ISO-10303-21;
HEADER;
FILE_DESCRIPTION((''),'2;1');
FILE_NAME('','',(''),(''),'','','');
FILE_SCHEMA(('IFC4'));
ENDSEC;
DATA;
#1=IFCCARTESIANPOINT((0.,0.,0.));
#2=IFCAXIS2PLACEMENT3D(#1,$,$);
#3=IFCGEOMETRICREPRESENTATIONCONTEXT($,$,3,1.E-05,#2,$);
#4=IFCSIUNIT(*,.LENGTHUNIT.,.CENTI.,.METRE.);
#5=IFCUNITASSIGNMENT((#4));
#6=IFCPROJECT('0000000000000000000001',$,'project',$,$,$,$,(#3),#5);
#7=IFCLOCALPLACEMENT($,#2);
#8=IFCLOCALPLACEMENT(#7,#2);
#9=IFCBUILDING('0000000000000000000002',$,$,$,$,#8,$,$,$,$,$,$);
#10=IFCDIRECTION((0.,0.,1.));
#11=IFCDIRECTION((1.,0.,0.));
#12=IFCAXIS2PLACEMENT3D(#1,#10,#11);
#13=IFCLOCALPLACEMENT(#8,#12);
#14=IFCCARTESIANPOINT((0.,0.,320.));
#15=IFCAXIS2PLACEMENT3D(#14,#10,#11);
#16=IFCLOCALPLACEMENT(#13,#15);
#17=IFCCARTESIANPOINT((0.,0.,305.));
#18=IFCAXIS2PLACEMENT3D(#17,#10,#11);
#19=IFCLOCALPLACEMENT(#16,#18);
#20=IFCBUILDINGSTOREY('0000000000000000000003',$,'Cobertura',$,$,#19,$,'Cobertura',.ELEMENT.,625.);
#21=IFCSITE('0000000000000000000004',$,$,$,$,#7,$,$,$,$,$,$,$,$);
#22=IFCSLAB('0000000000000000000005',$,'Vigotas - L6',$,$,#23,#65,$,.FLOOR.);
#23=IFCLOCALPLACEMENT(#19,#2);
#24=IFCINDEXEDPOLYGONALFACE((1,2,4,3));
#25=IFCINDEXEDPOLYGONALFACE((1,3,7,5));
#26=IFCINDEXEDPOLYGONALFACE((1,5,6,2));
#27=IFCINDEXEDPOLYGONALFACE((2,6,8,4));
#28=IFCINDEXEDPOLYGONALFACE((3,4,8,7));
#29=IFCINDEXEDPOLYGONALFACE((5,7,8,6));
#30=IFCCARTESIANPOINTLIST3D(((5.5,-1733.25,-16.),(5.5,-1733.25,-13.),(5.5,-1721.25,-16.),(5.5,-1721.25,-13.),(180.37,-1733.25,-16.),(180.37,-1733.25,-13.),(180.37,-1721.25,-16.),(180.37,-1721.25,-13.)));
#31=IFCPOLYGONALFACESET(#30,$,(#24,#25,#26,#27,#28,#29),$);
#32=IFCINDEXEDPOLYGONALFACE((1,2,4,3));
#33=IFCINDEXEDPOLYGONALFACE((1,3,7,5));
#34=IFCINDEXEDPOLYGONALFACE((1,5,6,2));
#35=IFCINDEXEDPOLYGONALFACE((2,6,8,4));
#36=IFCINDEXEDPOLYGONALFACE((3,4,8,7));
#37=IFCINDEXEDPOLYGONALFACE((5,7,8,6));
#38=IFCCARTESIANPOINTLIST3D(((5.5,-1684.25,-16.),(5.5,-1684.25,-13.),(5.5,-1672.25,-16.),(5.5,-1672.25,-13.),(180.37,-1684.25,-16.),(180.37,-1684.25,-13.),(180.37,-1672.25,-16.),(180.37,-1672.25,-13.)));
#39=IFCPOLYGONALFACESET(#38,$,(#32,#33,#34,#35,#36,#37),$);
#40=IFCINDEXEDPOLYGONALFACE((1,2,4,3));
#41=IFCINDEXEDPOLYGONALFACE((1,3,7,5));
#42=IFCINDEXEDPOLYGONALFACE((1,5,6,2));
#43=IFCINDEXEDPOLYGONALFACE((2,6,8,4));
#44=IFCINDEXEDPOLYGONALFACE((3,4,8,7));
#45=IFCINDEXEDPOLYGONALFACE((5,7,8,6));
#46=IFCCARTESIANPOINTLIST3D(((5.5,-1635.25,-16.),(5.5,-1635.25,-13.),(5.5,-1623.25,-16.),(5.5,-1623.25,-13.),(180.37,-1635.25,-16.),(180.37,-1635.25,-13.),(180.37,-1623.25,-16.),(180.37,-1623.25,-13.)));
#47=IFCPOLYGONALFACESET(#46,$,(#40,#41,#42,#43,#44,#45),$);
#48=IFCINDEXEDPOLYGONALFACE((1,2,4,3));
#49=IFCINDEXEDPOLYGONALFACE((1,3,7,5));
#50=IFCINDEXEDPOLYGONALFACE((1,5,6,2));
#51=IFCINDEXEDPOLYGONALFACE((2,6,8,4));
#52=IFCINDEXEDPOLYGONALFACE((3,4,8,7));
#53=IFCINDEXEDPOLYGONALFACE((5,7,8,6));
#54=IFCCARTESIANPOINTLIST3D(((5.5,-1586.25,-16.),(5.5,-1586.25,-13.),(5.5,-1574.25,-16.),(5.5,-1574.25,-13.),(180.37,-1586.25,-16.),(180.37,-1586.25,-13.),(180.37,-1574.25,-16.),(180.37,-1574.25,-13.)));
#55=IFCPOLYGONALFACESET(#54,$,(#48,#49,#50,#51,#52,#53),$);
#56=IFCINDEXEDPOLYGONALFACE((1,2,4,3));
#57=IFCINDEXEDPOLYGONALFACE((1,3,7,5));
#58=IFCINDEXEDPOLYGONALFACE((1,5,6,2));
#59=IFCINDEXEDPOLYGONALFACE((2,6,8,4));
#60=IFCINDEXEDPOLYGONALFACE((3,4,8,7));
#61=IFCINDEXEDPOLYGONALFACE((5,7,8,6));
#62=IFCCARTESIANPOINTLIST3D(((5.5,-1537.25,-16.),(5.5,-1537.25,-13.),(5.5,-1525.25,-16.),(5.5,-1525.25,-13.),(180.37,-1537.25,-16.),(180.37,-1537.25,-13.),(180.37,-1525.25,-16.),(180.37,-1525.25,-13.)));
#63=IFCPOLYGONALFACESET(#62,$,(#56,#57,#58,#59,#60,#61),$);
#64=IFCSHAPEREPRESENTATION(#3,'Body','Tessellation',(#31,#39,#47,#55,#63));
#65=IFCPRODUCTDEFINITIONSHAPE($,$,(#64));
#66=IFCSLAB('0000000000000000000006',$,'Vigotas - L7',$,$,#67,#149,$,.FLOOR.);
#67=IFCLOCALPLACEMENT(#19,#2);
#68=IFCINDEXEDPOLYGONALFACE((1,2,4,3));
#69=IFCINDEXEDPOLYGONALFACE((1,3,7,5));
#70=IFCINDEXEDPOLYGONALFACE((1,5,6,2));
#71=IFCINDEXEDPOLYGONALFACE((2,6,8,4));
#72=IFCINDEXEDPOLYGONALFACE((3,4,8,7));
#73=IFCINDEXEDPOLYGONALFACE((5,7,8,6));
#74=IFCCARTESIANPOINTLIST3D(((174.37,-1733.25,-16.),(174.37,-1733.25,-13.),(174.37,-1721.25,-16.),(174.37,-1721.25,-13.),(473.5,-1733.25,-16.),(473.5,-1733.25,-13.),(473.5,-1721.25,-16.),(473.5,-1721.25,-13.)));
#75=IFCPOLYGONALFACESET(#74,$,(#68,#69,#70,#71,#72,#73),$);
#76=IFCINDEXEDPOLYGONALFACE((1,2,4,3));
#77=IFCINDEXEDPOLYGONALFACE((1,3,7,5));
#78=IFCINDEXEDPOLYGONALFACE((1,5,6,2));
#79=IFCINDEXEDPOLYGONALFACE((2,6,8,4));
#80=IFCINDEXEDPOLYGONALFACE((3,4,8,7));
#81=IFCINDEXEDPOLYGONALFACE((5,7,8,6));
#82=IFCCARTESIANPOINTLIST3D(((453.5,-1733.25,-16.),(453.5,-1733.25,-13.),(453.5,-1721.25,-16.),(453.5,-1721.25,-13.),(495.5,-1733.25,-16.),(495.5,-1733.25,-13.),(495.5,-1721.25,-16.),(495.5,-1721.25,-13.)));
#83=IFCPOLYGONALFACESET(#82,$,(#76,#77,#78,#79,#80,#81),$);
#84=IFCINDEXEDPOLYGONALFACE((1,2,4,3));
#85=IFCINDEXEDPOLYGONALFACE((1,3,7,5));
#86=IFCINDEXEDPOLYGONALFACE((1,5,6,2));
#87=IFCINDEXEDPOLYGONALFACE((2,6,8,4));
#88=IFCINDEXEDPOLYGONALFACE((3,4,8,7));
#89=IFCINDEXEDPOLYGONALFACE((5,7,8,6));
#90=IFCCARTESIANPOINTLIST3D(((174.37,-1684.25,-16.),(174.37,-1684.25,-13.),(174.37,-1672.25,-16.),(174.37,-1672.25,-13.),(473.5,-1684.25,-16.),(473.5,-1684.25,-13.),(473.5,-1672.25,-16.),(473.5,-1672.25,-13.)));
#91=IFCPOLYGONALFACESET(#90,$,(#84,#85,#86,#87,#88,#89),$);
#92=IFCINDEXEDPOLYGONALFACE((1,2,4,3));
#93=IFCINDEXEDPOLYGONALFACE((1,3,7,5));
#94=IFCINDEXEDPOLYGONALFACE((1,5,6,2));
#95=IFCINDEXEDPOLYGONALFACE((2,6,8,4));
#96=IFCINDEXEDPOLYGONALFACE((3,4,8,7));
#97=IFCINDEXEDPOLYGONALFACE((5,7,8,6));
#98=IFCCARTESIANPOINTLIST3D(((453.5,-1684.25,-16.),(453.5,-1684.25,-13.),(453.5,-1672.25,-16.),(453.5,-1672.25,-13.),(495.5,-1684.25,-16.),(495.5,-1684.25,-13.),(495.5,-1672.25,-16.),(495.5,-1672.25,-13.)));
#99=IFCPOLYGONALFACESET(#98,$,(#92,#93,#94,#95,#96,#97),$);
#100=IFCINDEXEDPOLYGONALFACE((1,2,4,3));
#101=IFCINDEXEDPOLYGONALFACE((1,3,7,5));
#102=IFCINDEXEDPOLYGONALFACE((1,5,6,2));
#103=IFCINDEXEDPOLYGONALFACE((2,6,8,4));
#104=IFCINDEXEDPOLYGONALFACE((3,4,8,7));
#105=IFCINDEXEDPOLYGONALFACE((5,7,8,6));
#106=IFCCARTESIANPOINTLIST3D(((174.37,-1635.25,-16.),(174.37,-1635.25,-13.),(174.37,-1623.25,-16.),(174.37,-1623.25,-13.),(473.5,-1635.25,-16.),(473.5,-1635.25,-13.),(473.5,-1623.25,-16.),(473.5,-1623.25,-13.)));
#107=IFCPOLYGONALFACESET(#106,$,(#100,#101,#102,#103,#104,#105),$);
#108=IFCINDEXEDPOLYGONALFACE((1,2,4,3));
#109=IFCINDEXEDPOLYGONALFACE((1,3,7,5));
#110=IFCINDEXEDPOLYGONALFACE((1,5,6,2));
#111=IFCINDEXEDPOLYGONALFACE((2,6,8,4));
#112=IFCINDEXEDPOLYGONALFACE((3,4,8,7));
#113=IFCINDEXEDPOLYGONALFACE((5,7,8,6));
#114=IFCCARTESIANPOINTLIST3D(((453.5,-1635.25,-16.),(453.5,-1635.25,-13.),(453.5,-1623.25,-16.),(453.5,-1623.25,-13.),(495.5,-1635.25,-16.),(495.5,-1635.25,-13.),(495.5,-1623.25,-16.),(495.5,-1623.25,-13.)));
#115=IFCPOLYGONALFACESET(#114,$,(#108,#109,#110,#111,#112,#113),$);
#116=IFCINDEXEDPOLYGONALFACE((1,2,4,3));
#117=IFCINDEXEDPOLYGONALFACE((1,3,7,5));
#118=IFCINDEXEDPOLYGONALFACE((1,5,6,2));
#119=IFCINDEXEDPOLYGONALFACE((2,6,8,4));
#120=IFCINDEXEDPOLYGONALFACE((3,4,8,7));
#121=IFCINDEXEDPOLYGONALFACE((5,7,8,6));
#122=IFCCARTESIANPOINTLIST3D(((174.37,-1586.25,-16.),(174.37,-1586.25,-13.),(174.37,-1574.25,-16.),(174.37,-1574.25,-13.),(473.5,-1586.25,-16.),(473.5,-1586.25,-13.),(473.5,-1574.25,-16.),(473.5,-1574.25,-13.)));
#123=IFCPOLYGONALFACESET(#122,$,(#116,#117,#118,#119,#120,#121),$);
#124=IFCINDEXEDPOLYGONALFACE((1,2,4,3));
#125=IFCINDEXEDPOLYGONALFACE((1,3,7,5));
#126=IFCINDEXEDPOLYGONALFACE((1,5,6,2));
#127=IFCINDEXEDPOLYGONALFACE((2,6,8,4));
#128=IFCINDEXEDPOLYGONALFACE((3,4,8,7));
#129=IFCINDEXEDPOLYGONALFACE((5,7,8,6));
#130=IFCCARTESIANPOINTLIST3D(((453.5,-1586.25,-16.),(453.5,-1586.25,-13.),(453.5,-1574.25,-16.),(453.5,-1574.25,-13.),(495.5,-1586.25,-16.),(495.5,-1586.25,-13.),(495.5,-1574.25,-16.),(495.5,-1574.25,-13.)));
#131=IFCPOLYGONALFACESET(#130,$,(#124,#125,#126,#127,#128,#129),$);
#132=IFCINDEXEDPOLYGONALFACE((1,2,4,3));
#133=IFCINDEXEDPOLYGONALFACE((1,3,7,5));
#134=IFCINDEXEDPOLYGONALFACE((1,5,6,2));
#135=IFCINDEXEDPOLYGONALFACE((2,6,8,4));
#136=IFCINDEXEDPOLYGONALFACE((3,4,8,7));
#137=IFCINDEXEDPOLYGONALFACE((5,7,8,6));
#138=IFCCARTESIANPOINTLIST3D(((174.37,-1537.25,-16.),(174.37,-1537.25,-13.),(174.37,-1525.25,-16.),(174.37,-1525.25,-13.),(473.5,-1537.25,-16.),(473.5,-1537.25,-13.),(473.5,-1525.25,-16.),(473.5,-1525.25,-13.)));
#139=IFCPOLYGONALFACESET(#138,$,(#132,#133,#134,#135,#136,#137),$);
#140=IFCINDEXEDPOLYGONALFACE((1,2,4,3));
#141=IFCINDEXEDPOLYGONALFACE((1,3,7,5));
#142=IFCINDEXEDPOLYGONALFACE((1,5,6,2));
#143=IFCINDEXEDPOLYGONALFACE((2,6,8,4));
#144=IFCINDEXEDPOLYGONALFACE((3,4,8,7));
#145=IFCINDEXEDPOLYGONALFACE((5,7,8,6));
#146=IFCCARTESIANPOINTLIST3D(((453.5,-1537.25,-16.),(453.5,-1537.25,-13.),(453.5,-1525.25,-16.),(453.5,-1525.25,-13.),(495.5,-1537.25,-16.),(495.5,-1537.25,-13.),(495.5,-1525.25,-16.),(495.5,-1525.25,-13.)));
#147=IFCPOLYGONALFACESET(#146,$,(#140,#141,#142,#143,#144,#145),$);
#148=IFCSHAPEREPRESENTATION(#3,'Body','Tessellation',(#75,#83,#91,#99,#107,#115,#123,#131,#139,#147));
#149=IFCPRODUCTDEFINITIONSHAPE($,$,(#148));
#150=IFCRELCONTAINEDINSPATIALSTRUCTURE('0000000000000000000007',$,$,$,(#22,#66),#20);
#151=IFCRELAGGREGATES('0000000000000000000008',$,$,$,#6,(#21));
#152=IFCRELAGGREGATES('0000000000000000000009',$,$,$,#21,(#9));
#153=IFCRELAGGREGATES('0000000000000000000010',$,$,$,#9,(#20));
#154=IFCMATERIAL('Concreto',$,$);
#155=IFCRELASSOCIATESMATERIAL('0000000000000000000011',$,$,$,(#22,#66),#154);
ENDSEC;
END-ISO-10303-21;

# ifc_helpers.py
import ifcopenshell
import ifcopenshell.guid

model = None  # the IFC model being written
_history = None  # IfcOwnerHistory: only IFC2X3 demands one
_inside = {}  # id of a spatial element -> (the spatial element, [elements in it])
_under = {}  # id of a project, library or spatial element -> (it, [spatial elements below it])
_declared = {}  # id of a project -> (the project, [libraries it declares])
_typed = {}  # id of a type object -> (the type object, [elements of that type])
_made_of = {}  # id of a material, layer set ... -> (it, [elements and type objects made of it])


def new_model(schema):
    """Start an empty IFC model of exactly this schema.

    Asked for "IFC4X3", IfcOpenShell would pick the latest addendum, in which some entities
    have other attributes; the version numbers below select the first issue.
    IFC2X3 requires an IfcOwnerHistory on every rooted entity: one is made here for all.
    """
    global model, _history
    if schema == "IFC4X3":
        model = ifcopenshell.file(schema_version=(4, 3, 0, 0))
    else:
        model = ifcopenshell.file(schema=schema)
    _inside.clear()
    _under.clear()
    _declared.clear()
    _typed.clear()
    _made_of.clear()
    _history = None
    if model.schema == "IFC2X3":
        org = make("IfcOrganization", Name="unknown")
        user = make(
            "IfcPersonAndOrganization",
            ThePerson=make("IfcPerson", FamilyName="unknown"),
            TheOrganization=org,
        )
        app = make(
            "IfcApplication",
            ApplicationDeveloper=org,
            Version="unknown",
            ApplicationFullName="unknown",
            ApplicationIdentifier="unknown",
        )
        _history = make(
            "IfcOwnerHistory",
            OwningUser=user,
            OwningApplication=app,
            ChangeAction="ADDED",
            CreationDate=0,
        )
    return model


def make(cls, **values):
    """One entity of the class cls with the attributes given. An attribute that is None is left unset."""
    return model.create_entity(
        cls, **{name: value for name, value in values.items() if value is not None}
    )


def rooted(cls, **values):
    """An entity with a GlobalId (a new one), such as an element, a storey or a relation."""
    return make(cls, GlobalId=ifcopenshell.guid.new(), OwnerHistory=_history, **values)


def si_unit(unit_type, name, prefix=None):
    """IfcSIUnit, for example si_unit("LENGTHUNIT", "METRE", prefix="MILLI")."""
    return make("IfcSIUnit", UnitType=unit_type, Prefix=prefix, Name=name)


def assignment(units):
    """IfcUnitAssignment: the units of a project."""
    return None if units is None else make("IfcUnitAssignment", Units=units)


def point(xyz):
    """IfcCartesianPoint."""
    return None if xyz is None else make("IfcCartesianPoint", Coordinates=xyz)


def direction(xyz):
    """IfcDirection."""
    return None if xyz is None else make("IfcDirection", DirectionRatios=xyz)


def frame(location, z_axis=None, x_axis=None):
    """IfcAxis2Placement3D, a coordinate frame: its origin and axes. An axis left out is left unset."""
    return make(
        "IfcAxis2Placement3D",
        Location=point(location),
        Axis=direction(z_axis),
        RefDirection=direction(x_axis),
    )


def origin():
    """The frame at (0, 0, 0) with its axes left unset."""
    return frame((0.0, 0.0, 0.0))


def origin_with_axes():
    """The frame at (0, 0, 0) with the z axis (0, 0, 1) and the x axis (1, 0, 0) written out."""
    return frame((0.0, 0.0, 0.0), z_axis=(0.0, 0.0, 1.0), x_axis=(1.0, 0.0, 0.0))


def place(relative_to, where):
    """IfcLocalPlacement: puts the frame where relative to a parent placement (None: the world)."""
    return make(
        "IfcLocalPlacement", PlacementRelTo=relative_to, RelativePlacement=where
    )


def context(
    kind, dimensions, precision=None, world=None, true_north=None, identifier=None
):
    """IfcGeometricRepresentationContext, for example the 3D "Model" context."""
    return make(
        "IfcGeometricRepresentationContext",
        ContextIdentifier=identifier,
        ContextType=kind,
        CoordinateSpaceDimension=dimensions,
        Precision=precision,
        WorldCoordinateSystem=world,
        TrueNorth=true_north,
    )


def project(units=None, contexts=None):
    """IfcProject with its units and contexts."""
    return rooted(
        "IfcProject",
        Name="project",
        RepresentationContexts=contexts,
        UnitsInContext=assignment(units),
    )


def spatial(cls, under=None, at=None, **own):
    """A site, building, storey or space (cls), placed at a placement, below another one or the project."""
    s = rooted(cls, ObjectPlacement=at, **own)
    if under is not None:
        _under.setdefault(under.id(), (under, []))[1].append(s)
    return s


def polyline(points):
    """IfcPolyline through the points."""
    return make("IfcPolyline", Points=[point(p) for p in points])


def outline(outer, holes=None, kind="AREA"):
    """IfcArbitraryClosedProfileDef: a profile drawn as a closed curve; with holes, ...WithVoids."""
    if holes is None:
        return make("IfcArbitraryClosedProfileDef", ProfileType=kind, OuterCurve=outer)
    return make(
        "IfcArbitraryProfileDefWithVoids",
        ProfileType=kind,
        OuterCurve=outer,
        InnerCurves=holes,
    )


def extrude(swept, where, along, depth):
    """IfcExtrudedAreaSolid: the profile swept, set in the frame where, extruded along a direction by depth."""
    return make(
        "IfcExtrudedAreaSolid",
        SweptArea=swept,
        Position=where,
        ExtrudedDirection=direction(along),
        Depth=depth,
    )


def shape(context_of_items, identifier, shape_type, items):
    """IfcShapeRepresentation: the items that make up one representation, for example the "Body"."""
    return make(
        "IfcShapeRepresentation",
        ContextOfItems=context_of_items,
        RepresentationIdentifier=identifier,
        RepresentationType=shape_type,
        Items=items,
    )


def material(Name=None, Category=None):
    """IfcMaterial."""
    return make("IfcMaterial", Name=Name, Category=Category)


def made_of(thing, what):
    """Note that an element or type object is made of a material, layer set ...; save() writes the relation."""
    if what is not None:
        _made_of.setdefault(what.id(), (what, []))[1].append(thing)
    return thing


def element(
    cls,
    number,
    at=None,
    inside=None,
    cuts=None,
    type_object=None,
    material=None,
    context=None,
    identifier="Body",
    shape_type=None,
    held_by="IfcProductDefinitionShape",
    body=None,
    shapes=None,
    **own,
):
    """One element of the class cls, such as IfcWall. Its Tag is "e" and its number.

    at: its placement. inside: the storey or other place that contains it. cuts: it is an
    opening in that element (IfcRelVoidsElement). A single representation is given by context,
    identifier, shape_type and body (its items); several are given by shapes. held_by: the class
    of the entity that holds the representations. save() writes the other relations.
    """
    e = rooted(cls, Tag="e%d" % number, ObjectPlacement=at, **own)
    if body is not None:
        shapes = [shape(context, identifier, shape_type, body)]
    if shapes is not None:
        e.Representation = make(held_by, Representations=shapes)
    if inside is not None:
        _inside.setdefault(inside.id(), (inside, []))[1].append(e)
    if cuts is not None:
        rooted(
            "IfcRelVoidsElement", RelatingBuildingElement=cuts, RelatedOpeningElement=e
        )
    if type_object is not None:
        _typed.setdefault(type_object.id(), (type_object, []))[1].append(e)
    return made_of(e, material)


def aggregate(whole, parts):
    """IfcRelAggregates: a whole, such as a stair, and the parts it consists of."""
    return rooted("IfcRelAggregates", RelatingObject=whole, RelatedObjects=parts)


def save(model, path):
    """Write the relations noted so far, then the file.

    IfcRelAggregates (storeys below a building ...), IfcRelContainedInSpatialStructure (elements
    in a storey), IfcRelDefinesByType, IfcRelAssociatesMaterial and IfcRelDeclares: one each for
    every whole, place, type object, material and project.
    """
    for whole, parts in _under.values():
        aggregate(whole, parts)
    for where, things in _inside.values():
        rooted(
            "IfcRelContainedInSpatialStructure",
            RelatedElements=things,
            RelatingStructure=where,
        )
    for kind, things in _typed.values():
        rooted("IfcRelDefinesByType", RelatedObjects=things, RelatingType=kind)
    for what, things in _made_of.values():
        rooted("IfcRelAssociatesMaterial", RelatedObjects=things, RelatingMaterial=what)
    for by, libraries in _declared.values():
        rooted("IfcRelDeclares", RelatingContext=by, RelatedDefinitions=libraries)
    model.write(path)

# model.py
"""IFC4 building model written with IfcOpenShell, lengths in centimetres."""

from ifc_helpers import new_model, si_unit, frame, origin, origin_with_axes, place, context, project, spatial, polyline, outline, extrude, material, element, save


model = new_model("IFC4")

# Units and contexts
context_of_model = context(None, 3, precision=1e-05, world=origin())
ifc_project = project(units=[si_unit("LENGTHUNIT", "METRE", prefix="CENTI")], contexts=[context_of_model])

# Site, building, storey
site_placement = place(None, origin())
site = spatial("IfcSite", under=ifc_project, at=site_placement)
building_placement = place(site_placement, origin())
building = spatial("IfcBuilding", under=site, at=building_placement)
placement_1 = place(building_placement, origin_with_axes())
placement_2 = place(placement_1, frame((0.0, 0.0, 320.0), z_axis=(0.0, 0.0, 1.0), x_axis=(1.0, 0.0, 0.0)))
storey_placement = place(placement_2, frame((0.0, 0.0, 305.0), z_axis=(0.0, 0.0, 1.0), x_axis=(1.0, 0.0, 0.0)))
storey = spatial("IfcBuildingStorey", under=building, at=storey_placement, Name="Cobertura", LongName="Cobertura", CompositionType="ELEMENT", Elevation=625.0)

# Shared definitions
ifc_material = material(Name="Concreto")

# Slabs
slab_1_placement = place(storey_placement, frame((92.94, -1629.25, -13.0), z_axis=(0.0, 0.0, 1.0), x_axis=(1.0, 0.0, 0.0)))
element("IfcSlab", 1, at=slab_1_placement, inside=storey, material=ifc_material, Name="Vigotas - L6", PredefinedType="FLOOR", context=context_of_model, shape_type="SolidModel", body=[
    extrude(outline(polyline([(6.0, 1.5), (-6.0, 1.5), (-6.0, -1.5), (6.0, -1.5), (6.0, 1.5), (6.0, 1.5)])), frame((-87.44, -98.0, -1.5), z_axis=(1.0, 0.0, 0.0), x_axis=(0.0, -1.0, 0.0)), (0.0, 0.0, 1.0), 174.87),
    extrude(outline(polyline([(6.0, 1.5), (-6.0, 1.5), (-6.0, -1.5), (6.0, -1.5), (6.0, 1.5), (6.0, 1.5)])), frame((-87.44, -49.0, -1.5), z_axis=(1.0, 0.0, 0.0), x_axis=(0.0, -1.0, 0.0)), (0.0, 0.0, 1.0), 174.87),
    extrude(outline(polyline([(6.0, 1.5), (-6.0, 1.5), (-6.0, -1.5), (6.0, -1.5), (6.0, 1.5), (6.0, 1.5)])), frame((-87.44, 0.0, -1.5), z_axis=(1.0, 0.0, 0.0), x_axis=(0.0, -1.0, 0.0)), (0.0, 0.0, 1.0), 174.87),
    extrude(outline(polyline([(6.0, 1.5), (-6.0, 1.5), (-6.0, -1.5), (6.0, -1.5), (6.0, 1.5), (6.0, 1.5)])), frame((-87.44, 49.0, -1.5), z_axis=(1.0, 0.0, 0.0), x_axis=(0.0, -1.0, 0.0)), (0.0, 0.0, 1.0), 174.87),
    extrude(outline(polyline([(6.0, 1.5), (-6.0, 1.5), (-6.0, -1.5), (6.0, -1.5), (6.0, 1.5), (6.0, 1.5)])), frame((-87.44, 98.0, -1.5), z_axis=(1.0, 0.0, 0.0), x_axis=(0.0, -1.0, 0.0)), (0.0, 0.0, 1.0), 174.87),
])
slab_2_placement = place(storey_placement, frame((334.94, -1629.25, -13.0), z_axis=(0.0, 0.0, 1.0), x_axis=(1.0, 0.0, 0.0)))
element("IfcSlab", 2, at=slab_2_placement, inside=storey, material=ifc_material, Name="Vigotas - L7", PredefinedType="FLOOR", context=context_of_model, shape_type="SolidModel", body=[
    extrude(outline(polyline([(6.0, 1.5), (-6.0, 1.5), (-6.0, -1.5), (6.0, -1.5), (6.0, 1.5), (6.0, 1.5)])), frame((-160.56, -98.0, -1.5), z_axis=(1.0, 0.0, 0.0), x_axis=(0.0, -1.0, 0.0)), (0.0, 0.0, 1.0), 299.13),
    extrude(outline(polyline([(6.0, 1.5), (-6.0, 1.5), (-6.0, -1.5), (6.0, -1.5), (6.0, 1.5), (6.0, 1.5)])), frame((118.56, -98.0, -1.5), z_axis=(1.0, 0.0, 0.0), x_axis=(0.0, -1.0, 0.0)), (0.0, 0.0, 1.0), 42.0),
    extrude(outline(polyline([(6.0, 1.5), (-6.0, 1.5), (-6.0, -1.5), (6.0, -1.5), (6.0, 1.5), (6.0, 1.5)])), frame((-160.56, -49.0, -1.5), z_axis=(1.0, 0.0, 0.0), x_axis=(0.0, -1.0, 0.0)), (0.0, 0.0, 1.0), 299.13),
    extrude(outline(polyline([(6.0, 1.5), (-6.0, 1.5), (-6.0, -1.5), (6.0, -1.5), (6.0, 1.5), (6.0, 1.5)])), frame((118.56, -49.0, -1.5), z_axis=(1.0, 0.0, 0.0), x_axis=(0.0, -1.0, 0.0)), (0.0, 0.0, 1.0), 42.0),
    extrude(outline(polyline([(6.0, 1.5), (-6.0, 1.5), (-6.0, -1.5), (6.0, -1.5), (6.0, 1.5), (6.0, 1.5)])), frame((-160.56, 0.0, -1.5), z_axis=(1.0, 0.0, 0.0), x_axis=(0.0, -1.0, 0.0)), (0.0, 0.0, 1.0), 299.13),
    extrude(outline(polyline([(6.0, 1.5), (-6.0, 1.5), (-6.0, -1.5), (6.0, -1.5), (6.0, 1.5), (6.0, 1.5)])), frame((118.56, 0.0, -1.5), z_axis=(1.0, 0.0, 0.0), x_axis=(0.0, -1.0, 0.0)), (0.0, 0.0, 1.0), 42.0),
    extrude(outline(polyline([(6.0, 1.5), (-6.0, 1.5), (-6.0, -1.5), (6.0, -1.5), (6.0, 1.5), (6.0, 1.5)])), frame((-160.56, 49.0, -1.5), z_axis=(1.0, 0.0, 0.0), x_axis=(0.0, -1.0, 0.0)), (0.0, 0.0, 1.0), 299.13),
    extrude(outline(polyline([(6.0, 1.5), (-6.0, 1.5), (-6.0, -1.5), (6.0, -1.5), (6.0, 1.5), (6.0, 1.5)])), frame((118.56, 49.0, -1.5), z_axis=(1.0, 0.0, 0.0), x_axis=(0.0, -1.0, 0.0)), (0.0, 0.0, 1.0), 42.0),
    extrude(outline(polyline([(6.0, 1.5), (-6.0, 1.5), (-6.0, -1.5), (6.0, -1.5), (6.0, 1.5), (6.0, 1.5)])), frame((-160.56, 98.0, -1.5), z_axis=(1.0, 0.0, 0.0), x_axis=(0.0, -1.0, 0.0)), (0.0, 0.0, 1.0), 299.13),
    extrude(outline(polyline([(6.0, 1.5), (-6.0, 1.5), (-6.0, -1.5), (6.0, -1.5), (6.0, 1.5), (6.0, 1.5)])), frame((118.56, 98.0, -1.5), z_axis=(1.0, 0.0, 0.0), x_axis=(0.0, -1.0, 0.0)), (0.0, 0.0, 1.0), 42.0),
])

save(model, "model.ifc")
